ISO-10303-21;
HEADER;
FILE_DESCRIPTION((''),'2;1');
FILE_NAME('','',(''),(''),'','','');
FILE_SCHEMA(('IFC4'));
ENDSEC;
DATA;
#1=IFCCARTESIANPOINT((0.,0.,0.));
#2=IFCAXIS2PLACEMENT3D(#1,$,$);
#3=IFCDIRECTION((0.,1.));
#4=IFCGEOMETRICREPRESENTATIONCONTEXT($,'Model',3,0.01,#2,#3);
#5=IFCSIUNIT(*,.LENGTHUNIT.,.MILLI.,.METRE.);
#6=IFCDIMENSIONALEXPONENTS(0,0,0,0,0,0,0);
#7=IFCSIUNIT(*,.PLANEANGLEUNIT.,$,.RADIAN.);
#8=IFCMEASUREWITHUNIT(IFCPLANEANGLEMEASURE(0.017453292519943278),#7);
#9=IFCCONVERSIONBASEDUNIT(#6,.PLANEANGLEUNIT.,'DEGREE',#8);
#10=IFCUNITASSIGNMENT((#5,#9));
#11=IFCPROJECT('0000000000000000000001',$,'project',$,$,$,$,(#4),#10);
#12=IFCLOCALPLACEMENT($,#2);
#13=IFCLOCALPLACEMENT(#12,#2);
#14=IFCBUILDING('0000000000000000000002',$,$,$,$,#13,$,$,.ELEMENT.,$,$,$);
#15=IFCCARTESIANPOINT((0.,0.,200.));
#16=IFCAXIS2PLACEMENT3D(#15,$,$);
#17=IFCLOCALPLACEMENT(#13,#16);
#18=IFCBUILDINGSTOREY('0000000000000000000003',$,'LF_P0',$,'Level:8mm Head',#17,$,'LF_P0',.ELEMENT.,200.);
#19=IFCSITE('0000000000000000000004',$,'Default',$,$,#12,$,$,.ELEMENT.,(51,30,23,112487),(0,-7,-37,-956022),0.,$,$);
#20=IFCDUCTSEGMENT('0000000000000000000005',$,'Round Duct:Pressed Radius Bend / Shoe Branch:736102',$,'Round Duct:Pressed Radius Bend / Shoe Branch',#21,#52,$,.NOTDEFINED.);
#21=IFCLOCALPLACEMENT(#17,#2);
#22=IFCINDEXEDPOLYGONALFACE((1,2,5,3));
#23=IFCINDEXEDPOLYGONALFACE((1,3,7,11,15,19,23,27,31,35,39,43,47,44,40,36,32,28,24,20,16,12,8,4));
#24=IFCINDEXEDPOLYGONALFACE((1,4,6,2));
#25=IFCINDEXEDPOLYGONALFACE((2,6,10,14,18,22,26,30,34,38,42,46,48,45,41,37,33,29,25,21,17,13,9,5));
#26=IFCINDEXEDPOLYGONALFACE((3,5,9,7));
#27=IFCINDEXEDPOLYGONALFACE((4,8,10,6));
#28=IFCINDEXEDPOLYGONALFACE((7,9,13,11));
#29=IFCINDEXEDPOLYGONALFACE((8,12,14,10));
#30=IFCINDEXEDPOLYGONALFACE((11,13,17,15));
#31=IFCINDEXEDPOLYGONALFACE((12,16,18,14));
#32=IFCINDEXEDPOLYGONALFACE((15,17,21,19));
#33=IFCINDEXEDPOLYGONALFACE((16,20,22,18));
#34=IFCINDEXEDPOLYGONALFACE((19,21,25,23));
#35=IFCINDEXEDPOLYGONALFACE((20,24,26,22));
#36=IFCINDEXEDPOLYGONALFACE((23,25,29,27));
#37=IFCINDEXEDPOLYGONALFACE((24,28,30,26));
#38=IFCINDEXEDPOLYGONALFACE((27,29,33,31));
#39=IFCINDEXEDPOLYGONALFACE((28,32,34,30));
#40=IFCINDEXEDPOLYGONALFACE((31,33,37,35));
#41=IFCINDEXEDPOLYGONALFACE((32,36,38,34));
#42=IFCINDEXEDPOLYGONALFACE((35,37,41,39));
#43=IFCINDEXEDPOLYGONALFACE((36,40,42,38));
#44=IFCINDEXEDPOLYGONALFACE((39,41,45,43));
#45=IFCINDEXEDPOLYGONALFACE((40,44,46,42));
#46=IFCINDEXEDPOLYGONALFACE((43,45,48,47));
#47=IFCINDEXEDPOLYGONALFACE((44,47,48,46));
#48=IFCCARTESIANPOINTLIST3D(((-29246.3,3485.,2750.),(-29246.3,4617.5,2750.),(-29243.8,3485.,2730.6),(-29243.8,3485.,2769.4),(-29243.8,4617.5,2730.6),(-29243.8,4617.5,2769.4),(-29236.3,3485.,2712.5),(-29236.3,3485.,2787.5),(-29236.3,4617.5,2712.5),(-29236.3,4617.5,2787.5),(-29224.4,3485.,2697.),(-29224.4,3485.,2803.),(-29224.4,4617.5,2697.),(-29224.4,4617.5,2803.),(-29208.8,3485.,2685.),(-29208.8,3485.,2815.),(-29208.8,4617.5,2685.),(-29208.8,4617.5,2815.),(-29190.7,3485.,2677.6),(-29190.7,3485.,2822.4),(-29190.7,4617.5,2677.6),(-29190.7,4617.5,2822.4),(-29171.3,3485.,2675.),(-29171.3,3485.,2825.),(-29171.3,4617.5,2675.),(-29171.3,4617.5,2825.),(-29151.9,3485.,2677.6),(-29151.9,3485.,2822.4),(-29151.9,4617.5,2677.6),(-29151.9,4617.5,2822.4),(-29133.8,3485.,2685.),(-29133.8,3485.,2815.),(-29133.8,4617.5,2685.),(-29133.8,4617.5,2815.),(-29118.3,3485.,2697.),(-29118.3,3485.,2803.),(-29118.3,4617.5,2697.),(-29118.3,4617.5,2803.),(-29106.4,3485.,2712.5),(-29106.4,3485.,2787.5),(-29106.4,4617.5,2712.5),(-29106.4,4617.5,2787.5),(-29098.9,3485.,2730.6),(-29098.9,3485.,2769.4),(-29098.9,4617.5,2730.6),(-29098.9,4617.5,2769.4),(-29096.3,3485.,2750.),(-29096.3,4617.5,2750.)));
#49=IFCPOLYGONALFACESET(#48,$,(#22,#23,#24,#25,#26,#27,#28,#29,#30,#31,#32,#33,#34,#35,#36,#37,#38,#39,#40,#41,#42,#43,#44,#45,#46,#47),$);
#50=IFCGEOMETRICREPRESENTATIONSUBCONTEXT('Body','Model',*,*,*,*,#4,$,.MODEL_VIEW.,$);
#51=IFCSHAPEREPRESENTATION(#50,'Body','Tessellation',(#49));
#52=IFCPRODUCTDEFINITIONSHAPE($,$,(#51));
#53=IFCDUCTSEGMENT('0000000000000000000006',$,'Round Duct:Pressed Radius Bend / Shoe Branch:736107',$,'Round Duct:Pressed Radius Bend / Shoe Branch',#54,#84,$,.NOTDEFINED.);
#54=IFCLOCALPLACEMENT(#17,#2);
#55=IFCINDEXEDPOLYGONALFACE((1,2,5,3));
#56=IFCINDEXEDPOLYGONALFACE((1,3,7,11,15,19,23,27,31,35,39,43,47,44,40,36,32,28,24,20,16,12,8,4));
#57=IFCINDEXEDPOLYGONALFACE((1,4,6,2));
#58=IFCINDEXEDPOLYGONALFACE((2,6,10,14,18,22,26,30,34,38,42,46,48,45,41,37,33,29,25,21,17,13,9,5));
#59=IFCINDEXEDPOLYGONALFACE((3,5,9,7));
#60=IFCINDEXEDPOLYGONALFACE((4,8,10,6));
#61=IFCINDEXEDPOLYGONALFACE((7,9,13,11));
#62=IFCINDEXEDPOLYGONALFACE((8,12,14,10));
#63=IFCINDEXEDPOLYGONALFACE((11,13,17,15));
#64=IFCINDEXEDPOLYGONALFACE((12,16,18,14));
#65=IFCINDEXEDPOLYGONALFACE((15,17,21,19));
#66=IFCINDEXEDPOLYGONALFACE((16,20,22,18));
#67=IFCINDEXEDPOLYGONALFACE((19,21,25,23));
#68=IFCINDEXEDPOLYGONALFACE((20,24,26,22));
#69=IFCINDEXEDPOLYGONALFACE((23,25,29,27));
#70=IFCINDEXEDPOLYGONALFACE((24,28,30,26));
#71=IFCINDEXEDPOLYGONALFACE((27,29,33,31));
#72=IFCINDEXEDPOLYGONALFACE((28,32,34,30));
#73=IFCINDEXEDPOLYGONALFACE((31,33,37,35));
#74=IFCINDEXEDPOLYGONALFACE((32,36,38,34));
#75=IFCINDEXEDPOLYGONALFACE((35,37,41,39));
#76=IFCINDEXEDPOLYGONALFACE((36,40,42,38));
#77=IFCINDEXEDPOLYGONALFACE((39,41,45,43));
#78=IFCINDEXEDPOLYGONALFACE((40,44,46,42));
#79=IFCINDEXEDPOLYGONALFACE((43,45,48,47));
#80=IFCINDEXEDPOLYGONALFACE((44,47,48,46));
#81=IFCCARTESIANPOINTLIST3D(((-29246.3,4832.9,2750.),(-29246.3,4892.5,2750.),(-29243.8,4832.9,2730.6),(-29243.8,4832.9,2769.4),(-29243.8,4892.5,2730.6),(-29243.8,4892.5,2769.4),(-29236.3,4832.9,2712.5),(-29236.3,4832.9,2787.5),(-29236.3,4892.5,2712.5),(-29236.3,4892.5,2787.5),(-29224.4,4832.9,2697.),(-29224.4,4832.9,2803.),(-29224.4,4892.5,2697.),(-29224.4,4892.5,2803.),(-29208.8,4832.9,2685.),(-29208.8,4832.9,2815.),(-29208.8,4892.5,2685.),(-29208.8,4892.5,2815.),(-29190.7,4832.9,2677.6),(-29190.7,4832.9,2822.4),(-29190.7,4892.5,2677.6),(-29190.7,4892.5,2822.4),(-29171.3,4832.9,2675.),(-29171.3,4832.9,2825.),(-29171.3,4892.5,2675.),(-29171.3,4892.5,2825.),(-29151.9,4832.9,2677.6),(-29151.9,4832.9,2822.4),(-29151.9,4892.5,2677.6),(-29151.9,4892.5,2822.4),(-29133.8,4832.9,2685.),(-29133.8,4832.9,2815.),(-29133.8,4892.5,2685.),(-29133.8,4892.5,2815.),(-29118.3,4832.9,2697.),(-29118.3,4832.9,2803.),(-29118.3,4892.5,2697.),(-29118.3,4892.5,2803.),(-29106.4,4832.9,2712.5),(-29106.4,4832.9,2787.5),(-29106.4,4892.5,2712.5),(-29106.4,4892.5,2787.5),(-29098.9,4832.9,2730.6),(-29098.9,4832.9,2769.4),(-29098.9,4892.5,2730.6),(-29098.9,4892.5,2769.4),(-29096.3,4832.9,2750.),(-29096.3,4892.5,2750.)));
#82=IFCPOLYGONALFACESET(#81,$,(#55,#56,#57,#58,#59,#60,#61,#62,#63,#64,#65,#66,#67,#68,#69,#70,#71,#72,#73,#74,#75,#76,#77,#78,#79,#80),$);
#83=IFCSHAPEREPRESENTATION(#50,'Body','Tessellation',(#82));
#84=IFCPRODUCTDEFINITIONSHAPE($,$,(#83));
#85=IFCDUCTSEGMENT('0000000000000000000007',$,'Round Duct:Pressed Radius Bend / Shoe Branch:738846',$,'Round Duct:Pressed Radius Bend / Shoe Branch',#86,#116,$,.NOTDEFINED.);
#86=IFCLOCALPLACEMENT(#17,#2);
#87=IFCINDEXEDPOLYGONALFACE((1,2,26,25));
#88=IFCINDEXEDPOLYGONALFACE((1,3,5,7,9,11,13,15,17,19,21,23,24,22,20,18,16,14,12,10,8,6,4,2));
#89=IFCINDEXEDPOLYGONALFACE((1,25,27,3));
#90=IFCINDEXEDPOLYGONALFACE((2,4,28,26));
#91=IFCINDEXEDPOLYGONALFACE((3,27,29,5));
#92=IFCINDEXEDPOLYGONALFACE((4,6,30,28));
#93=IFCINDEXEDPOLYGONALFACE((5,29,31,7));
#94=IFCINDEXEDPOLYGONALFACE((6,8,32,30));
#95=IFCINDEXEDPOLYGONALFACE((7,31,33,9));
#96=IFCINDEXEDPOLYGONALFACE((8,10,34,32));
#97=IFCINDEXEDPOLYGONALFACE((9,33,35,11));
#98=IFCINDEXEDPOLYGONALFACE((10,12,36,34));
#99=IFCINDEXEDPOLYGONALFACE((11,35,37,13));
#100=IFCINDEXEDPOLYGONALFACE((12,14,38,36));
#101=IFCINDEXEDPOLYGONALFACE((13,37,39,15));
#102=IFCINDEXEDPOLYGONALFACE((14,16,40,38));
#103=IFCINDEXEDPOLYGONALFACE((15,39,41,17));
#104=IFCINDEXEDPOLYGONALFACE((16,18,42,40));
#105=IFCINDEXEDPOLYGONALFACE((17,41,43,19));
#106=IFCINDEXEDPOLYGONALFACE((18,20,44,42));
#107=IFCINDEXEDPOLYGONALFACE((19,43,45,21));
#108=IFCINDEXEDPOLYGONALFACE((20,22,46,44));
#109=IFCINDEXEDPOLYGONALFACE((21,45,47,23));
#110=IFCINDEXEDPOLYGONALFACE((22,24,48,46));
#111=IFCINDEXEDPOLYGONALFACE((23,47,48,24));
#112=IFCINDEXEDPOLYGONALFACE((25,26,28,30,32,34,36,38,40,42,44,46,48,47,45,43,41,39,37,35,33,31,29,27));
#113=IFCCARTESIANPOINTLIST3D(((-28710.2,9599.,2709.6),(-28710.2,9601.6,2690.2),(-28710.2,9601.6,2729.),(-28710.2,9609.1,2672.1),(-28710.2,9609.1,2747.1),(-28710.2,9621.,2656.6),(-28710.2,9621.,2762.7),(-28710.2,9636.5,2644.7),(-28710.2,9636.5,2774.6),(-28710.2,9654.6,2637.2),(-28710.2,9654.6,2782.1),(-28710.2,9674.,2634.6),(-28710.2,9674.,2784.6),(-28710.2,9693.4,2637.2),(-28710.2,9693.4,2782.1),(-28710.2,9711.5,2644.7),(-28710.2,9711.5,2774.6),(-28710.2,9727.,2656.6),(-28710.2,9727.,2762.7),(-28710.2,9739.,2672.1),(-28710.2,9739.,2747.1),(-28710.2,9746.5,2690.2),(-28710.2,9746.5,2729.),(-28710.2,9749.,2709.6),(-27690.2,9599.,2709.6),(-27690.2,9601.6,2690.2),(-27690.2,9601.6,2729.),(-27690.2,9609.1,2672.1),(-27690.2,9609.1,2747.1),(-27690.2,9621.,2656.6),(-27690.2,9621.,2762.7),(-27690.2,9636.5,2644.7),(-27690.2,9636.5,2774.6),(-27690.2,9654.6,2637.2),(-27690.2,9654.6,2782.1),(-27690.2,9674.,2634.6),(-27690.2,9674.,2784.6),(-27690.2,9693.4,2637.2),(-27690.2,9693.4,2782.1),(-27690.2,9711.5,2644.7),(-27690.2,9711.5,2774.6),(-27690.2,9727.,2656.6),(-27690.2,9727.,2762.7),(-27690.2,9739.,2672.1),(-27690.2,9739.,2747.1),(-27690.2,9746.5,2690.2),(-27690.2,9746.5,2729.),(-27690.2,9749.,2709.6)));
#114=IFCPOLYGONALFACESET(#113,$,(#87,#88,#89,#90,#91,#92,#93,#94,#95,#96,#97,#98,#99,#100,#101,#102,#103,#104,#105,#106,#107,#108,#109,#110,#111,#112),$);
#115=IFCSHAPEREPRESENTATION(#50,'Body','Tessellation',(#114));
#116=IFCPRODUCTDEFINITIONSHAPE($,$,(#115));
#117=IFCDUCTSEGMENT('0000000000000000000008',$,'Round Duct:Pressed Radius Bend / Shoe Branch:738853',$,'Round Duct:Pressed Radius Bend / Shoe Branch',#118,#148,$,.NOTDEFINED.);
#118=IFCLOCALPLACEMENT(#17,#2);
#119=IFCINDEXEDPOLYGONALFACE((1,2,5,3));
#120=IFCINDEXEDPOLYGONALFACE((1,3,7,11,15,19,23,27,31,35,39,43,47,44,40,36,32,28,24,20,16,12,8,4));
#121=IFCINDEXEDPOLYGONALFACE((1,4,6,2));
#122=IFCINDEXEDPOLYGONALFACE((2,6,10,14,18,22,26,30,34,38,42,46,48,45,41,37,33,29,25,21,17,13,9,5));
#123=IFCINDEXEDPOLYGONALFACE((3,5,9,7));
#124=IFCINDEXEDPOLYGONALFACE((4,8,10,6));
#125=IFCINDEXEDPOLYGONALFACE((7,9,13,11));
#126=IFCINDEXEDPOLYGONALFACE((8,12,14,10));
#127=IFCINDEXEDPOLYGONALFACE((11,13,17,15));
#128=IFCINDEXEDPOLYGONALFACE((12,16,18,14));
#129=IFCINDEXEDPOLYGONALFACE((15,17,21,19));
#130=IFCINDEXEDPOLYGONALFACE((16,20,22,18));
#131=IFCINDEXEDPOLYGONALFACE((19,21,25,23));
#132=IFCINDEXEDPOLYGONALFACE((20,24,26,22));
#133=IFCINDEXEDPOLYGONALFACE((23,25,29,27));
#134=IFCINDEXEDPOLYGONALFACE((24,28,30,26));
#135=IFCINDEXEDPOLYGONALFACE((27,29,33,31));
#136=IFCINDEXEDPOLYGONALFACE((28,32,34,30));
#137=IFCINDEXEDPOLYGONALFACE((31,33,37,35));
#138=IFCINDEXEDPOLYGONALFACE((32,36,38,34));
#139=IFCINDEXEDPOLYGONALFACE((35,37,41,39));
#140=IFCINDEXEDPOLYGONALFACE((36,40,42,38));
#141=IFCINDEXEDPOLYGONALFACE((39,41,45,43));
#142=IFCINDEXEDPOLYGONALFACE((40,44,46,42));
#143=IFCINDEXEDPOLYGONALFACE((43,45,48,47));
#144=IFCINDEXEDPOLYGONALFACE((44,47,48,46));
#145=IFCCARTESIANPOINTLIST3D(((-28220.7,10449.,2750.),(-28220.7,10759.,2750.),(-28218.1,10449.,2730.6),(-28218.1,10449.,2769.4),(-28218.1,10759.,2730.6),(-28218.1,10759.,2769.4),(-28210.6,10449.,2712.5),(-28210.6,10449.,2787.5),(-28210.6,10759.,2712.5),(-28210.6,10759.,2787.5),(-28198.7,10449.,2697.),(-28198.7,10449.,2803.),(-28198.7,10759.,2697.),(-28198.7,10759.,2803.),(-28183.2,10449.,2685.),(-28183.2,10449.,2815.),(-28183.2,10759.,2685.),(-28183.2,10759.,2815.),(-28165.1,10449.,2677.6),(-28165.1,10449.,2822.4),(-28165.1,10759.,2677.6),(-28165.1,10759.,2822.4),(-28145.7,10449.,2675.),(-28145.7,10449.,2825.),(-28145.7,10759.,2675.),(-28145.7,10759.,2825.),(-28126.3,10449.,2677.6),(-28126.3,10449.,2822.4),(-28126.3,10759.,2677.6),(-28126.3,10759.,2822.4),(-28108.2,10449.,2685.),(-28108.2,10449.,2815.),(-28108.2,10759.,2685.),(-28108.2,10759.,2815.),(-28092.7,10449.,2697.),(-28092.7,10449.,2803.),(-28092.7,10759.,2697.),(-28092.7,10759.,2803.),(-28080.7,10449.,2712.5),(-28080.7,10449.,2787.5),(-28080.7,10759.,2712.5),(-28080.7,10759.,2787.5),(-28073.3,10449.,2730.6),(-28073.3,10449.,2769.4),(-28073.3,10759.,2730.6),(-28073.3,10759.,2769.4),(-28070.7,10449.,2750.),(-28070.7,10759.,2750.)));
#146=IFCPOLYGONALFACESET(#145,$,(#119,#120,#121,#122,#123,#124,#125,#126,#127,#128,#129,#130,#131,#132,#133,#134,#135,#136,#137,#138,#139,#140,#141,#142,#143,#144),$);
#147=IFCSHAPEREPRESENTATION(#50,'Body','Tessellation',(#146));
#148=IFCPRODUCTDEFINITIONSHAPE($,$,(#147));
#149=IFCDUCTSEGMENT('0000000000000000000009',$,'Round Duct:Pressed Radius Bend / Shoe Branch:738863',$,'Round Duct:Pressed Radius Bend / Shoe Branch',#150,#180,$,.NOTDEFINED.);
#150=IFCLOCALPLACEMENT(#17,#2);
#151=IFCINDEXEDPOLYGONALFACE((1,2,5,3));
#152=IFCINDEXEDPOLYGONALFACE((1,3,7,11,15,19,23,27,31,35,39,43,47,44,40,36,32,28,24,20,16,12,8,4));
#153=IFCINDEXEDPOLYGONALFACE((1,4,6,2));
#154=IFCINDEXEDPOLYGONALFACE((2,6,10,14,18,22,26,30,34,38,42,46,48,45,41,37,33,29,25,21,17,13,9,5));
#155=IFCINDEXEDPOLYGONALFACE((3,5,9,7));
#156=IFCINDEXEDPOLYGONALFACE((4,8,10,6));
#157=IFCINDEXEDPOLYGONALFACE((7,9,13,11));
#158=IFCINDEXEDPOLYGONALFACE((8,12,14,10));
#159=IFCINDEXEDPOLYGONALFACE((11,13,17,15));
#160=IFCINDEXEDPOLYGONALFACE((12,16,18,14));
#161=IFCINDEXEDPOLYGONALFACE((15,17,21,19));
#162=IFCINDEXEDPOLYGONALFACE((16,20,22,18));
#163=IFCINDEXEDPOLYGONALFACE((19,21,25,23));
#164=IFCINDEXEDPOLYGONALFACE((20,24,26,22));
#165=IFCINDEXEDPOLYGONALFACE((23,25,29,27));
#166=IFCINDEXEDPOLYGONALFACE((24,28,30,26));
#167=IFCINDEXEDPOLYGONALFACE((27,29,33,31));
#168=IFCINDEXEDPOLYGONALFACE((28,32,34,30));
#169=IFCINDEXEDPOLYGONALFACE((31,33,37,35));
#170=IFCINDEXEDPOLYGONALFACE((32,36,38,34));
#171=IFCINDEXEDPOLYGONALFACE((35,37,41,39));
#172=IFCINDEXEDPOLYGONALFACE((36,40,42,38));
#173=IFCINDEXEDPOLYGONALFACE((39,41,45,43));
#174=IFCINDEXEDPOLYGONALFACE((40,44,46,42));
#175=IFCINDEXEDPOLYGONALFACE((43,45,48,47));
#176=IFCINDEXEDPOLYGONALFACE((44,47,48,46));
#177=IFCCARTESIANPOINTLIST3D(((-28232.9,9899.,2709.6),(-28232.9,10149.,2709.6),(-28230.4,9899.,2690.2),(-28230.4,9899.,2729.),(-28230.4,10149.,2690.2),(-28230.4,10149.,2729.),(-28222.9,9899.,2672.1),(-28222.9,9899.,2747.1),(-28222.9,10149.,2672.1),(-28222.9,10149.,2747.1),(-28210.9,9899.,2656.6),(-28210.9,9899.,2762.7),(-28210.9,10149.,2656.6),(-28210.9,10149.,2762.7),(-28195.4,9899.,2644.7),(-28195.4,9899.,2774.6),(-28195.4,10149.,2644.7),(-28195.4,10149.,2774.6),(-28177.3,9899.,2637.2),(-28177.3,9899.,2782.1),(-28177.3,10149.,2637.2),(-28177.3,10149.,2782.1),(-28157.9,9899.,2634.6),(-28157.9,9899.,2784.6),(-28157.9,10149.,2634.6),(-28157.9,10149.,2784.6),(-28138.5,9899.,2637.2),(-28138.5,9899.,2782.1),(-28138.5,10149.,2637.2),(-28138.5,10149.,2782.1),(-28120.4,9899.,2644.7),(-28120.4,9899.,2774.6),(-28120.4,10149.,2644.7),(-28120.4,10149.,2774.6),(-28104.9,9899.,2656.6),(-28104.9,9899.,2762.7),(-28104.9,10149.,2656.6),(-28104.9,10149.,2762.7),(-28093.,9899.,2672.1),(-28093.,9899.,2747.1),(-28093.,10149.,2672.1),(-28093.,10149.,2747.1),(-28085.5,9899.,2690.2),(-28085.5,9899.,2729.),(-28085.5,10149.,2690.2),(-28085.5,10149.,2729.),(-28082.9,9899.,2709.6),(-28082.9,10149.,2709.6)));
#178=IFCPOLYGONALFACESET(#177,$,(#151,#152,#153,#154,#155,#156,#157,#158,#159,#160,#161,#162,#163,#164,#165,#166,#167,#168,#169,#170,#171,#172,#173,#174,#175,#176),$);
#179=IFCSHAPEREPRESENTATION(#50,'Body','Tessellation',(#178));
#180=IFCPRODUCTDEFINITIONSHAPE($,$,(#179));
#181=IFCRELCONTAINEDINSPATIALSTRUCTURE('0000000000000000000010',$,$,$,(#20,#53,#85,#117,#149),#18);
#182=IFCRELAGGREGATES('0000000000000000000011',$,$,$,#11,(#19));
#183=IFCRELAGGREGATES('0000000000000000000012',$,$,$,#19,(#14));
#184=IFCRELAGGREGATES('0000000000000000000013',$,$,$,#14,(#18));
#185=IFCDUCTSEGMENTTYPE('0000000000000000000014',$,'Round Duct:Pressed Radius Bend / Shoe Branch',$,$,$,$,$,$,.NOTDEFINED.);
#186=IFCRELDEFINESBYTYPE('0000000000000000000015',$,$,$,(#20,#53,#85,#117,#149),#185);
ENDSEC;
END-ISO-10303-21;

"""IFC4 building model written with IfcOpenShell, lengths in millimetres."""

from ifc_helpers import new_model, entity, si_unit, converted_unit, direction, frame, origin, place, context, subcontext, project, spatial, arc, indexed_curve, outline, extrude, type_object, element, save


model = new_model("IFC4")

# Units and contexts
model_context = context("Model", 3, precision=0.01, world=origin(), true_north=direction((0.0, 1.0)))
body_context = subcontext(model_context, "Body", "Model", "MODEL_VIEW")
ifc_project = project(units=[si_unit("LENGTHUNIT", "METRE", prefix="MILLI"), converted_unit("PLANEANGLEUNIT", "DEGREE", entity("IfcPlaneAngleMeasure", 0.017453292519943278), si_unit("PLANEANGLEUNIT", "RADIAN"), dimensions=[0, 0, 0, 0, 0, 0, 0])], contexts=[model_context])

# Site, building, storey
site_placement = place(None, origin())
site = spatial("IfcSite", under=ifc_project, at=site_placement, Name="Default", CompositionType="ELEMENT", RefLatitude=(51, 30, 23, 112487), RefLongitude=(0, -7, -37, -956022), RefElevation=0.0)
building_placement = place(site_placement, origin())
building = spatial("IfcBuilding", under=site, at=building_placement, CompositionType="ELEMENT")
storey_placement = place(building_placement, frame((0.0, 0.0, 200.0)))
storey = spatial("IfcBuildingStorey", under=building, at=storey_placement, Name="LF_P0", ObjectType="Level:8mm Head", LongName="LF_P0", CompositionType="ELEMENT", Elevation=200.0)

# Duct segments
duct_segment_type_1 = type_object("IfcDuctSegmentType", Name="Round Duct:Pressed Radius Bend / Shoe Branch", PredefinedType="NOTDEFINED")
duct_segment_1_placement = place(storey_placement, origin())
element("IfcDuctSegment", 1, at=duct_segment_1_placement, inside=storey, type_object=duct_segment_type_1, Name="Round Duct:Pressed Radius Bend / Shoe Branch:736102", ObjectType="Round Duct:Pressed Radius Bend / Shoe Branch", PredefinedType="NOTDEFINED", context=body_context, shape_type="SweptSolid", body=[
    extrude(outline(indexed_curve([(75.0, 0.0), (53.0, 53.0), (0.0, 75.0), (-53.0, 53.0), (-75.0, 0.0), (-53.0, -53.0), (0.0, -75.0), (53.0, -53.0)], segments=[arc(1, 2, 3), arc(3, 4, 5), arc(5, 6, 7), arc(7, 8, 1)], self_intersect=False)), frame((-29171.3, 3485.0, 2750.0), z_axis=(0.0, 1.0, 0.0), x_axis=(1.0, 0.0, 0.0)), (0.0, 0.0, 1.0), 1132.5),
])
duct_segment_2_placement = place(storey_placement, origin())
element("IfcDuctSegment", 2, at=duct_segment_2_placement, inside=storey, type_object=duct_segment_type_1, Name="Round Duct:Pressed Radius Bend / Shoe Branch:736107", ObjectType="Round Duct:Pressed Radius Bend / Shoe Branch", PredefinedType="NOTDEFINED", context=body_context, shape_type="SweptSolid", body=[
    extrude(outline(indexed_curve([(75.0, 0.0), (53.0, 53.0), (0.0, 75.0), (-53.0, 53.0), (-75.0, 0.0), (-53.0, -53.0), (0.0, -75.0), (53.0, -53.0)], segments=[arc(1, 2, 3), arc(3, 4, 5), arc(5, 6, 7), arc(7, 8, 1)], self_intersect=False)), frame((-29171.3, 4832.9, 2750.0), z_axis=(0.0, 1.0, 0.0), x_axis=(-1.0, 0.0, 0.0)), (0.0, 0.0, 1.0), 59.6),
])
duct_segment_3_placement = place(storey_placement, origin())
element("IfcDuctSegment", 3, at=duct_segment_3_placement, inside=storey, type_object=duct_segment_type_1, Name="Round Duct:Pressed Radius Bend / Shoe Branch:738846", ObjectType="Round Duct:Pressed Radius Bend / Shoe Branch", PredefinedType="NOTDEFINED", context=body_context, shape_type="SweptSolid", body=[
    extrude(outline(indexed_curve([(75.0, 0.0), (53.0, 53.0), (0.0, 75.0), (-53.0, 53.0), (-75.0, 0.0), (-53.0, -53.0), (0.0, -75.0), (53.0, -53.0)], segments=[arc(1, 2, 3), arc(3, 4, 5), arc(5, 6, 7), arc(7, 8, 1)], self_intersect=False)), frame((-28710.2, 9674.0, 2709.6), z_axis=(1.0, 0.0, 0.0), x_axis=(0.0, 1.0, 0.0)), (0.0, 0.0, 1.0), 1020.0),
])
duct_segment_4_placement = place(storey_placement, origin())
element("IfcDuctSegment", 4, at=duct_segment_4_placement, inside=storey, type_object=duct_segment_type_1, Name="Round Duct:Pressed Radius Bend / Shoe Branch:738853", ObjectType="Round Duct:Pressed Radius Bend / Shoe Branch", PredefinedType="NOTDEFINED", context=body_context, shape_type="SweptSolid", body=[
    extrude(outline(indexed_curve([(75.0, 0.0), (53.0, 53.0), (0.0, 75.0), (-53.0, 53.0), (-75.0, 0.0), (-53.0, -53.0), (0.0, -75.0), (53.0, -53.0)], segments=[arc(1, 2, 3), arc(3, 4, 5), arc(5, 6, 7), arc(7, 8, 1)], self_intersect=False)), frame((-28145.7, 10449.0, 2750.0), z_axis=(0.0, 1.0, 0.0), x_axis=(-1.0, 0.0, 0.0)), (0.0, 0.0, 1.0), 310.0),
])
duct_segment_5_placement = place(storey_placement, origin())
element("IfcDuctSegment", 5, at=duct_segment_5_placement, inside=storey, type_object=duct_segment_type_1, Name="Round Duct:Pressed Radius Bend / Shoe Branch:738863", ObjectType="Round Duct:Pressed Radius Bend / Shoe Branch", PredefinedType="NOTDEFINED", context=body_context, shape_type="SweptSolid", body=[
    extrude(outline(indexed_curve([(75.0, 0.0), (53.0, 53.0), (0.0, 75.0), (-53.0, 53.0), (-75.0, 0.0), (-53.0, -53.0), (0.0, -75.0), (53.0, -53.0)], segments=[arc(1, 2, 3), arc(3, 4, 5), arc(5, 6, 7), arc(7, 8, 1)], self_intersect=False)), frame((-28157.9, 9899.0, 2709.6), z_axis=(0.0, 1.0, 0.0), x_axis=(1.0, 0.0, 0.0)), (0.0, 0.0, 1.0), 250.0),
])

save(model, "model.ifc")
